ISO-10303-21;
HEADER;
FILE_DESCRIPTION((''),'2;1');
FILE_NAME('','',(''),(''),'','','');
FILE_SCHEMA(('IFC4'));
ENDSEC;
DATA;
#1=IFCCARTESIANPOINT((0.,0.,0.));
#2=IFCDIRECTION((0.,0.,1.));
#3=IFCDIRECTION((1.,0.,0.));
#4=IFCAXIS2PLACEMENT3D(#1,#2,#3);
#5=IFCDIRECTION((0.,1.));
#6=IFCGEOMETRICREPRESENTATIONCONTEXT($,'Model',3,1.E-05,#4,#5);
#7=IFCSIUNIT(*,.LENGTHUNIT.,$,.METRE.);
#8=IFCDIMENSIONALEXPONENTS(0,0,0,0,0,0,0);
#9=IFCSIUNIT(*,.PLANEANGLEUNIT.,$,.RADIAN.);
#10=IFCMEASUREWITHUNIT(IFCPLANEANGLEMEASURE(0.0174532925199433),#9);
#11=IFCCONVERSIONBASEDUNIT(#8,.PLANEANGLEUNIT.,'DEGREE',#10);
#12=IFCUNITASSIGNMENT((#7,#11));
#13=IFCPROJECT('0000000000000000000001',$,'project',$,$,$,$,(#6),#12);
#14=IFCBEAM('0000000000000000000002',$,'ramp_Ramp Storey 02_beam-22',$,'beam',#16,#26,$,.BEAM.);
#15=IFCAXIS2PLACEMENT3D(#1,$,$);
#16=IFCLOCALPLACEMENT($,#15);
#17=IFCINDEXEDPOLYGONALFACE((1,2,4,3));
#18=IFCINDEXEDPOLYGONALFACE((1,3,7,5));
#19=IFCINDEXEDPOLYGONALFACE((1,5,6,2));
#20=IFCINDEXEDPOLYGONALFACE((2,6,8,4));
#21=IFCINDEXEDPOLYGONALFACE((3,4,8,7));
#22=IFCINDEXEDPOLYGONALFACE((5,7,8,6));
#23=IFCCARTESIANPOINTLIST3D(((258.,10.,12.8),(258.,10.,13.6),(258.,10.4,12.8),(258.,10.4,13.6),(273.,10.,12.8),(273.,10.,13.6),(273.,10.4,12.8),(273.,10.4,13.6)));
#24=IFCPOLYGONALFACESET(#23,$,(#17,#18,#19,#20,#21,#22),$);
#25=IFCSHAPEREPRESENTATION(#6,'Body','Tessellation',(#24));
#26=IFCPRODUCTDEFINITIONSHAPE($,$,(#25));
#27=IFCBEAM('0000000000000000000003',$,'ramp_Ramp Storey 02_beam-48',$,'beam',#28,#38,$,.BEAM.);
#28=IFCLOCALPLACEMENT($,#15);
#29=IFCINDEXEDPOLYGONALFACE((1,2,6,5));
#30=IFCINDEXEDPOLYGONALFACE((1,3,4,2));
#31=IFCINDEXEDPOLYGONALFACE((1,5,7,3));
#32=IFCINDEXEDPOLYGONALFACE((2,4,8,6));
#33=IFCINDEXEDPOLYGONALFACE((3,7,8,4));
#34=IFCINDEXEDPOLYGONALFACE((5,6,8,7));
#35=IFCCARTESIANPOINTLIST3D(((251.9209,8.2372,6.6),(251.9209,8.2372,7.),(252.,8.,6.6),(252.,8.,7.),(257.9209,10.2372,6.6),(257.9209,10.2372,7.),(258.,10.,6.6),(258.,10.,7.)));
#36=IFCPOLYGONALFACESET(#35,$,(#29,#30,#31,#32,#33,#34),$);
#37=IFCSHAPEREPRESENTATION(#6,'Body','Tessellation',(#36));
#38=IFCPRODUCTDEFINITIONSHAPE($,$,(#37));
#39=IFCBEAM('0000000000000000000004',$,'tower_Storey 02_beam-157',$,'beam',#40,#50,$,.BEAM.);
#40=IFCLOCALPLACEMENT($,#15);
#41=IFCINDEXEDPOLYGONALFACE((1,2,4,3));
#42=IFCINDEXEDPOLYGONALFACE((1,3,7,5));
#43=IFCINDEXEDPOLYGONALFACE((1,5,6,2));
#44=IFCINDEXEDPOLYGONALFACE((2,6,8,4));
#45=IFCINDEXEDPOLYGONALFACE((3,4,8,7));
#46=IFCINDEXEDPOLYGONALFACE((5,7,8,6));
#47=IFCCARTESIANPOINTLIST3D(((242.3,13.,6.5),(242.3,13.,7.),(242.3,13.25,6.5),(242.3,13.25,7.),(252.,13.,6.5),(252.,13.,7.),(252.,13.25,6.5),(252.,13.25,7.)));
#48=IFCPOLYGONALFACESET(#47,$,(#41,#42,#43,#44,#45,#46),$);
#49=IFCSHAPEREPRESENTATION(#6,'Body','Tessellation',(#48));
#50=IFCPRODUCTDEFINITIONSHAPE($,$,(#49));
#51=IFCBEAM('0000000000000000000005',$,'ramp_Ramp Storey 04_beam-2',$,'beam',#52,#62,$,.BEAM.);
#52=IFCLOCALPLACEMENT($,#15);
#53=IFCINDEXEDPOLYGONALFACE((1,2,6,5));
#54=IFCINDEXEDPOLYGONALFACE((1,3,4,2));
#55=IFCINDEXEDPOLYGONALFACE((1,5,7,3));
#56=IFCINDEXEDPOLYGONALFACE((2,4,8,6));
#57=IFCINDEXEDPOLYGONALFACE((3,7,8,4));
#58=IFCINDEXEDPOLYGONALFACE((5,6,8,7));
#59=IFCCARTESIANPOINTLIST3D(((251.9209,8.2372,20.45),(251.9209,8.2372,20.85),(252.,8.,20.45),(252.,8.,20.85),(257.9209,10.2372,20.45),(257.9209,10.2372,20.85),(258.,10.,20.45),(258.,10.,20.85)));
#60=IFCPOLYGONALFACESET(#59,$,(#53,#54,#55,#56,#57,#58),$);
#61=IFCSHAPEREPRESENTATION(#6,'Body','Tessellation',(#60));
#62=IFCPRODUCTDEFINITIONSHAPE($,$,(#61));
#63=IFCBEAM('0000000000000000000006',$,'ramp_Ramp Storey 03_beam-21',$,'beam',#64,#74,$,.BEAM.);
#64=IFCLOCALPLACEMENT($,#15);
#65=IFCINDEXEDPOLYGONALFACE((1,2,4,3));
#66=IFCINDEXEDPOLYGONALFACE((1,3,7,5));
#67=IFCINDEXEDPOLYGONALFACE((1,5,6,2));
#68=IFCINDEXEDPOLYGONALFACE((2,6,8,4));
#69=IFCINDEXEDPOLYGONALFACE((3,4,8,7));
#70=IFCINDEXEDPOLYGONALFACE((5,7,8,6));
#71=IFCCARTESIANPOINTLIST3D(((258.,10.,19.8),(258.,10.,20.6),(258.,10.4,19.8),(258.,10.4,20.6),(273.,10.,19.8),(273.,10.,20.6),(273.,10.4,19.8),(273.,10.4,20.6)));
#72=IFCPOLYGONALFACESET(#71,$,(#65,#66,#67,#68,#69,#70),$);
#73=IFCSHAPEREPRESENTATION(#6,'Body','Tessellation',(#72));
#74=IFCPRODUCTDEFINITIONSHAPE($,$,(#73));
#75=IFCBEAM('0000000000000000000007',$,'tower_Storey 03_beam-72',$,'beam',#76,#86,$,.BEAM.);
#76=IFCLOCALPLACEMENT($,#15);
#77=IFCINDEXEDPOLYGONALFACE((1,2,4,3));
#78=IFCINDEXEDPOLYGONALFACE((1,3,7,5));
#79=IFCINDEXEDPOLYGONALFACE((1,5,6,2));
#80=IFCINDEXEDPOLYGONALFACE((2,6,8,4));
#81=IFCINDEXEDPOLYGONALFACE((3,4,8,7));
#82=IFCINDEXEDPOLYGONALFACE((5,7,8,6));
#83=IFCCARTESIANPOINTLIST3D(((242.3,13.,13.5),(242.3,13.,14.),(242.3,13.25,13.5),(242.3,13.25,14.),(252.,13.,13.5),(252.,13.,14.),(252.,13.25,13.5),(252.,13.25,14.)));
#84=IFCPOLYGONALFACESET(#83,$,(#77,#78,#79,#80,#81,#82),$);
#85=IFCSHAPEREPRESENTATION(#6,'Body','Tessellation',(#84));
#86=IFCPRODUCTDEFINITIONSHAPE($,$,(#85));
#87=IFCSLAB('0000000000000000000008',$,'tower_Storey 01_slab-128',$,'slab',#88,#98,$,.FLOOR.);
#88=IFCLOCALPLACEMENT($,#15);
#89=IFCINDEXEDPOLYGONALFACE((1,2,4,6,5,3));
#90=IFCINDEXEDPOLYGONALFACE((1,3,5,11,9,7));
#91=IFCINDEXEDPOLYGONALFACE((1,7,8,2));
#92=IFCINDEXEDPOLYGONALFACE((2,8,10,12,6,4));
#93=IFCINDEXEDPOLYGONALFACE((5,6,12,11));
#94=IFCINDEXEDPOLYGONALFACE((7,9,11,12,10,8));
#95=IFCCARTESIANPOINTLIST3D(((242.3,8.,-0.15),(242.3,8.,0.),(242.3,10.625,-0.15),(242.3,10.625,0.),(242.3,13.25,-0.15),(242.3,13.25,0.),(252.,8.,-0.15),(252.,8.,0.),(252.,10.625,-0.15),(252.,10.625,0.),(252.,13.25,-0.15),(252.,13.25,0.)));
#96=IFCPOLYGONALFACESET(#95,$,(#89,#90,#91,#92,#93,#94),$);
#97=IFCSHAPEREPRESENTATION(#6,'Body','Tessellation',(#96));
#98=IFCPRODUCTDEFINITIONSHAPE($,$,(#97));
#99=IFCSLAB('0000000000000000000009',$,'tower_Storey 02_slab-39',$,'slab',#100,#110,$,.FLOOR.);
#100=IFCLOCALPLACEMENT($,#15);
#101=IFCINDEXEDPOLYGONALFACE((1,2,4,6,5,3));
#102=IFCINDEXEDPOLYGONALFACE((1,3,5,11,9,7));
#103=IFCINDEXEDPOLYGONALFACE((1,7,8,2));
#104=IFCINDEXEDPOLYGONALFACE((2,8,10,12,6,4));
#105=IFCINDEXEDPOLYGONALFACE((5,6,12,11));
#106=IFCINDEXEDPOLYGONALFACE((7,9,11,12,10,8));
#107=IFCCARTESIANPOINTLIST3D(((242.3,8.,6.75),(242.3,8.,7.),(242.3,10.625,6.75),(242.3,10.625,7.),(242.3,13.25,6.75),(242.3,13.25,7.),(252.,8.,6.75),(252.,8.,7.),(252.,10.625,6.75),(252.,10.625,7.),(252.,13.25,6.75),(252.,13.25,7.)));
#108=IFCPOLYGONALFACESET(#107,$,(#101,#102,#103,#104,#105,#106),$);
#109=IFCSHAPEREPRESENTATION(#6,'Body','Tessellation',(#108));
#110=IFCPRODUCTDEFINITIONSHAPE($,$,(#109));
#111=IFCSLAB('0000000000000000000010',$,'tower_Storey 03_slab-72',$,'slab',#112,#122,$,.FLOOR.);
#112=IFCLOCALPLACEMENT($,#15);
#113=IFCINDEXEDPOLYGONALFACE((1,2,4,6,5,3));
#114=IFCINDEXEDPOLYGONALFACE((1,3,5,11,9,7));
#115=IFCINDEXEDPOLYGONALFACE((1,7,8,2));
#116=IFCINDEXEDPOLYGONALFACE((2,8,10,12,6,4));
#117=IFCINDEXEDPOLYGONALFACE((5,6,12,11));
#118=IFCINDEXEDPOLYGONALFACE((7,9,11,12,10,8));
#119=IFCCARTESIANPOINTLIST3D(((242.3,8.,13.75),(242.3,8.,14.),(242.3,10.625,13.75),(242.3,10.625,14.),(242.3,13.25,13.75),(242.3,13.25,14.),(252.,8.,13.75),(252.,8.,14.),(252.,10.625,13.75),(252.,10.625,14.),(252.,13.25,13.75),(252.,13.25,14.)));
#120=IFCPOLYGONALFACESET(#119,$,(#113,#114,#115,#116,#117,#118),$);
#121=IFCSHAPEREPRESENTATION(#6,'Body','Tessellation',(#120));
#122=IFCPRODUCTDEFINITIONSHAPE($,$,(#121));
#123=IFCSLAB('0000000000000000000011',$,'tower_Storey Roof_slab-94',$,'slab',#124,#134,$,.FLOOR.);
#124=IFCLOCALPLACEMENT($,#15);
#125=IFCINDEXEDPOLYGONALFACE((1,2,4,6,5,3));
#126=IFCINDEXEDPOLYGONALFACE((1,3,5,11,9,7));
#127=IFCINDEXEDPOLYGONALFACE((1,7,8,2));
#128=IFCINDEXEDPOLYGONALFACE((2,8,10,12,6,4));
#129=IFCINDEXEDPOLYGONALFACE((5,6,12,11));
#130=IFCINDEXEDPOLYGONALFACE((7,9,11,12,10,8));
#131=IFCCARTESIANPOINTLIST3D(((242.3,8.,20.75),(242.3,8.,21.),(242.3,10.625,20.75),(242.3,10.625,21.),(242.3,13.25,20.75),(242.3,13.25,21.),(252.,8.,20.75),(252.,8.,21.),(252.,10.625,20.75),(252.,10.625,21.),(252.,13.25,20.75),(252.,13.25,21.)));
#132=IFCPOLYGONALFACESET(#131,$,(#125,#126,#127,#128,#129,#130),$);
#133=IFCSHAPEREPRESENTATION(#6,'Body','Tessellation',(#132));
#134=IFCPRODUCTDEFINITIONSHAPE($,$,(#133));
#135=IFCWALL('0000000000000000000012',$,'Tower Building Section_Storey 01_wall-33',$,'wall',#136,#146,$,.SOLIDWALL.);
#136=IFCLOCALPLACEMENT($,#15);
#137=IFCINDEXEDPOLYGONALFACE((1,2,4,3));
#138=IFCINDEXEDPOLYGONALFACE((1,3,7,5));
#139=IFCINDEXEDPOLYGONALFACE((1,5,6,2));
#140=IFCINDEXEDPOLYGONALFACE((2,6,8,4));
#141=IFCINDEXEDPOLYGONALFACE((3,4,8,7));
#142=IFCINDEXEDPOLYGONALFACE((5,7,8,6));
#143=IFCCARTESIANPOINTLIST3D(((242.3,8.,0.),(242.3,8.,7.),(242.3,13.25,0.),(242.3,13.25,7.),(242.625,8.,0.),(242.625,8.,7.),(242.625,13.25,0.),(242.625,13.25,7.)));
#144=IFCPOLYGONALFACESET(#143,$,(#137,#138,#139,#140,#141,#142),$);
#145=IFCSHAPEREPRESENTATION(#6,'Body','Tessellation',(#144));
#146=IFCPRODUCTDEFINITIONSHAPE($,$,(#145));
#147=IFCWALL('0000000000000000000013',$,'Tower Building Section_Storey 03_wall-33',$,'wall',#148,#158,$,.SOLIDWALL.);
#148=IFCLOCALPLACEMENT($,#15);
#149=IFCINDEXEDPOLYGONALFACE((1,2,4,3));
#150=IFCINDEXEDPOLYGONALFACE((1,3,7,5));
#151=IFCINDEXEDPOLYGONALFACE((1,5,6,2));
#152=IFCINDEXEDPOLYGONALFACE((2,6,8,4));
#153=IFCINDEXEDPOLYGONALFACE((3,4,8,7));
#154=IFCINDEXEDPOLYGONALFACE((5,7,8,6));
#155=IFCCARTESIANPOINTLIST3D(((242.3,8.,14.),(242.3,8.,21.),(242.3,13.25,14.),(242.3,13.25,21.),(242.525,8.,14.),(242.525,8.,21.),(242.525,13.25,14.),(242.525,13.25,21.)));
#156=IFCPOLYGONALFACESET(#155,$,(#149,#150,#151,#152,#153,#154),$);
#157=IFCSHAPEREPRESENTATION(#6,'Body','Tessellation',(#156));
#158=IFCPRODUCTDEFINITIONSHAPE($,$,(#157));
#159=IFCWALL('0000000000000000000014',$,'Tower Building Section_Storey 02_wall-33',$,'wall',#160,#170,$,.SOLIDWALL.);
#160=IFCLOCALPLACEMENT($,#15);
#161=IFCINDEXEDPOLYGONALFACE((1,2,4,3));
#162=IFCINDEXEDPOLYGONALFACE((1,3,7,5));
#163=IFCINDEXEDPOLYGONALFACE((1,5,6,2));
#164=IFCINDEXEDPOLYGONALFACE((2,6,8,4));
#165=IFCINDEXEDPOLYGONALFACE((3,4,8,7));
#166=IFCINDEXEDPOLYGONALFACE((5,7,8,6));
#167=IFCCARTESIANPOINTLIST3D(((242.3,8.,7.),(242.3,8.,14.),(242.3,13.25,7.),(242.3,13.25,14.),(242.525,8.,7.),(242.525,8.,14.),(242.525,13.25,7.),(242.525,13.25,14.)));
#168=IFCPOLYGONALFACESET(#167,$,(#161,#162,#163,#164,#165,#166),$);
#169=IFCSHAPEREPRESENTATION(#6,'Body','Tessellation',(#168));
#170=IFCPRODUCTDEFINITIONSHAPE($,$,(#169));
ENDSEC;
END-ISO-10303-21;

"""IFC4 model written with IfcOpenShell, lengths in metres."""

from ifc_helpers import new_model, entity, si_unit, converted_unit, direction, frame, origin_with_axes, place, context, project, polyline, outline, extrude, element, save


model = new_model("IFC4")

# Units and contexts
model_context = context("Model", 3, precision=1e-05, world=origin_with_axes(), true_north=direction((0.0, 1.0)))
ifc_project = project(units=[si_unit("LENGTHUNIT", "METRE"), converted_unit("PLANEANGLEUNIT", "DEGREE", entity("IfcPlaneAngleMeasure", 0.0174532925199433), si_unit("PLANEANGLEUNIT", "RADIAN"), dimensions=[0, 0, 0, 0, 0, 0, 0])], contexts=[model_context])

# Shared definitions
placement_1 = place(None, origin_with_axes())
placement_2 = place(placement_1, origin_with_axes())

# Shared definitions
placement_3 = place(placement_1, frame((0.0, 0.0, 14.0), z_axis=(0.0, 0.0, 1.0), x_axis=(1.0, 0.0, 0.0)))
placement_4 = place(placement_1, frame((0.0, 0.0, 7.0), z_axis=(0.0, 0.0, 1.0), x_axis=(1.0, 0.0, 0.0)))

# Beams
placement_5 = place(None, frame((258.0, -8.0, 0.0), z_axis=(0.0, 0.0, 1.0), x_axis=(1.0, 0.0, 0.0)))
placement_6 = place(placement_1, frame((0.0, 0.0, 21.0), z_axis=(0.0, 0.0, 1.0), x_axis=(1.0, 0.0, 0.0)))
placement_7 = place(placement_5, frame((0.0, 0.0, 14.0), z_axis=(0.0, 0.0, 1.0), x_axis=(1.0, 0.0, 0.0)))
placement_8 = place(placement_5, frame((0.0, 0.0, 7.0), z_axis=(0.0, 0.0, 1.0), x_axis=(1.0, 0.0, 0.0)))
beam_1_placement = place(placement_8, frame((0.0, 18.2, 6.2), z_axis=(1.0, 0.0, 0.0), x_axis=(0.0, 1.0, 0.0)))
element("IfcBeam", 1, at=beam_1_placement, Name="ramp_Ramp Storey 02_beam-22", ObjectType="beam", PredefinedType="BEAM", context=model_context, body=[
    extrude(outline(polyline([(0.2, 0.4, 0.0), (-0.2, 0.4, 0.0), (-0.2, -0.4, 0.0), (0.2, -0.4, 0.0), (0.2, 0.4, 0.0)])), origin_with_axes(), (0.0, 0.0, 1.0), 15.0),
])
beam_2_placement = place(placement_8, frame((-6.0395, 16.1186, -0.2), z_axis=(0.948683, 0.316228, 0.0), x_axis=(-0.316228, 0.948683, 0.0)))
element("IfcBeam", 2, at=beam_2_placement, Name="ramp_Ramp Storey 02_beam-48", ObjectType="beam", PredefinedType="BEAM", context=model_context, body=[
    extrude(outline(polyline([(0.125, 0.2, 0.0), (-0.125, 0.2, 0.0), (-0.125, -0.2, 0.0), (0.125, -0.2, 0.0), (0.125, 0.2, 0.0)])), origin_with_axes(), (0.0, 0.0, 1.0), 6.3246),
])
beam_3_placement = place(placement_4, frame((242.3, 13.125, -0.25), z_axis=(1.0, 0.0, 0.0), x_axis=(0.0, 1.0, 0.0)))
element("IfcBeam", 3, at=beam_3_placement, Name="tower_Storey 02_beam-157", ObjectType="beam", PredefinedType="BEAM", context=model_context, body=[
    extrude(outline(polyline([(0.125, 0.25, 0.0), (-0.125, 0.25, 0.0), (-0.125, -0.25, 0.0), (0.125, -0.25, 0.0), (0.125, 0.25, 0.0)])), origin_with_axes(), (0.0, 0.0, 1.0), 9.7),
])
placement_9 = place(placement_5, frame((0.0, 0.0, 21.0), z_axis=(0.0, 0.0, 1.0), x_axis=(1.0, 0.0, 0.0)))
beam_4_placement = place(placement_9, frame((-6.0395, 16.1186, -0.35), z_axis=(0.948683, 0.316228, 0.0), x_axis=(-0.316228, 0.948683, 0.0)))
element("IfcBeam", 4, at=beam_4_placement, Name="ramp_Ramp Storey 04_beam-2", ObjectType="beam", PredefinedType="BEAM", context=model_context, body=[
    extrude(outline(polyline([(0.125, 0.2, 0.0), (-0.125, 0.2, 0.0), (-0.125, -0.2, 0.0), (0.125, -0.2, 0.0), (0.125, 0.2, 0.0)])), origin_with_axes(), (0.0, 0.0, 1.0), 6.3246),
])
beam_5_placement = place(placement_7, frame((0.0, 18.2, 6.2), z_axis=(1.0, 0.0, 0.0), x_axis=(0.0, 1.0, 0.0)))
element("IfcBeam", 5, at=beam_5_placement, Name="ramp_Ramp Storey 03_beam-21", ObjectType="beam", PredefinedType="BEAM", context=model_context, body=[
    extrude(outline(polyline([(0.2, 0.4, 0.0), (-0.2, 0.4, 0.0), (-0.2, -0.4, 0.0), (0.2, -0.4, 0.0), (0.2, 0.4, 0.0)])), origin_with_axes(), (0.0, 0.0, 1.0), 15.0),
])
beam_6_placement = place(placement_3, frame((242.3, 13.125, -0.25), z_axis=(1.0, 0.0, 0.0), x_axis=(0.0, 1.0, 0.0)))
element("IfcBeam", 6, at=beam_6_placement, Name="tower_Storey 03_beam-72", ObjectType="beam", PredefinedType="BEAM", context=model_context, body=[
    extrude(outline(polyline([(0.125, 0.25, 0.0), (-0.125, 0.25, 0.0), (-0.125, -0.25, 0.0), (0.125, -0.25, 0.0), (0.125, 0.25, 0.0)])), origin_with_axes(), (0.0, 0.0, 1.0), 9.7),
])

# Slabs
slab_1_placement = place(placement_2, frame((247.15, 10.625, -0.15), z_axis=(0.0, 0.0, 1.0), x_axis=(1.0, 0.0, 0.0)))
element("IfcSlab", 7, at=slab_1_placement, Name="tower_Storey 01_slab-128", ObjectType="slab", PredefinedType="FLOOR", context=model_context, body=[
    extrude(outline(polyline([(-4.85, -2.625, 0.0), (4.85, -2.625, 0.0), (4.85, 0.0, 0.0), (4.85, 2.625, 0.0), (-4.85, 2.625, 0.0), (-4.85, 0.0, 0.0), (-4.85, -2.625, 0.0)])), origin_with_axes(), (0.0, 0.0, 1.0), 0.15),
])
slab_2_placement = place(placement_4, frame((247.15, 10.625, -0.25), z_axis=(0.0, 0.0, 1.0), x_axis=(1.0, 0.0, 0.0)))
element("IfcSlab", 8, at=slab_2_placement, Name="tower_Storey 02_slab-39", ObjectType="slab", PredefinedType="FLOOR", context=model_context, body=[
    extrude(outline(polyline([(-4.85, -2.625, 0.0), (4.85, -2.625, 0.0), (4.85, 0.0, 0.0), (4.85, 2.625, 0.0), (-4.85, 2.625, 0.0), (-4.85, 0.0, 0.0), (-4.85, -2.625, 0.0)])), origin_with_axes(), (0.0, 0.0, 1.0), 0.25),
])
slab_3_placement = place(placement_3, frame((247.15, 10.625, -0.25), z_axis=(0.0, 0.0, 1.0), x_axis=(1.0, 0.0, 0.0)))
element("IfcSlab", 9, at=slab_3_placement, Name="tower_Storey 03_slab-72", ObjectType="slab", PredefinedType="FLOOR", context=model_context, body=[
    extrude(outline(polyline([(-4.85, -2.625, 0.0), (4.85, -2.625, 0.0), (4.85, 0.0, 0.0), (4.85, 2.625, 0.0), (-4.85, 2.625, 0.0), (-4.85, 0.0, 0.0), (-4.85, -2.625, 0.0)])), origin_with_axes(), (0.0, 0.0, 1.0), 0.25),
])
slab_4_placement = place(placement_6, frame((247.15, 10.625, -0.25), z_axis=(0.0, 0.0, 1.0), x_axis=(1.0, 0.0, 0.0)))
element("IfcSlab", 10, at=slab_4_placement, Name="tower_Storey Roof_slab-94", ObjectType="slab", PredefinedType="FLOOR", context=model_context, body=[
    extrude(outline(polyline([(-4.85, -2.625, 0.0), (4.85, -2.625, 0.0), (4.85, 0.0, 0.0), (4.85, 2.625, 0.0), (-4.85, 2.625, 0.0), (-4.85, 0.0, 0.0), (-4.85, -2.625, 0.0)])), origin_with_axes(), (0.0, 0.0, 1.0), 0.25),
])

# Walls
wall_1_placement = place(placement_2, frame((242.625, 10.625, 3.5), z_axis=(-1.0, 0.0, 0.0), x_axis=(0.0, 0.0, 1.0)))
element("IfcWall", 11, at=wall_1_placement, Name="Tower Building Section_Storey 01_wall-33", ObjectType="wall", PredefinedType="SOLIDWALL", context=model_context, body=[
    extrude(outline(polyline([(-3.5, -2.625, 0.0), (3.5, -2.625, 0.0), (3.5, 2.625, 0.0), (-3.5, 2.625, 0.0), (-3.5, -2.625, 0.0)])), origin_with_axes(), (0.0, 0.0, 1.0), 0.325),
])
wall_2_placement = place(placement_3, frame((242.525, 10.625, 3.5), z_axis=(-1.0, 0.0, 0.0), x_axis=(0.0, 0.0, 1.0)))
element("IfcWall", 12, at=wall_2_placement, Name="Tower Building Section_Storey 03_wall-33", ObjectType="wall", PredefinedType="SOLIDWALL", context=model_context, body=[
    extrude(outline(polyline([(-3.5, -2.625, 0.0), (3.5, -2.625, 0.0), (3.5, 2.625, 0.0), (-3.5, 2.625, 0.0), (-3.5, -2.625, 0.0)])), origin_with_axes(), (0.0, 0.0, 1.0), 0.225),
])
wall_3_placement = place(placement_4, frame((242.525, 10.625, 3.5), z_axis=(-1.0, 0.0, 0.0), x_axis=(0.0, 0.0, 1.0)))
element("IfcWall", 13, at=wall_3_placement, Name="Tower Building Section_Storey 02_wall-33", ObjectType="wall", PredefinedType="SOLIDWALL", context=model_context, body=[
    extrude(outline(polyline([(-3.5, -2.625, 0.0), (3.5, -2.625, 0.0), (3.5, 2.625, 0.0), (-3.5, 2.625, 0.0), (-3.5, -2.625, 0.0)])), origin_with_axes(), (0.0, 0.0, 1.0), 0.225),
])

save(model, "model.ifc")
